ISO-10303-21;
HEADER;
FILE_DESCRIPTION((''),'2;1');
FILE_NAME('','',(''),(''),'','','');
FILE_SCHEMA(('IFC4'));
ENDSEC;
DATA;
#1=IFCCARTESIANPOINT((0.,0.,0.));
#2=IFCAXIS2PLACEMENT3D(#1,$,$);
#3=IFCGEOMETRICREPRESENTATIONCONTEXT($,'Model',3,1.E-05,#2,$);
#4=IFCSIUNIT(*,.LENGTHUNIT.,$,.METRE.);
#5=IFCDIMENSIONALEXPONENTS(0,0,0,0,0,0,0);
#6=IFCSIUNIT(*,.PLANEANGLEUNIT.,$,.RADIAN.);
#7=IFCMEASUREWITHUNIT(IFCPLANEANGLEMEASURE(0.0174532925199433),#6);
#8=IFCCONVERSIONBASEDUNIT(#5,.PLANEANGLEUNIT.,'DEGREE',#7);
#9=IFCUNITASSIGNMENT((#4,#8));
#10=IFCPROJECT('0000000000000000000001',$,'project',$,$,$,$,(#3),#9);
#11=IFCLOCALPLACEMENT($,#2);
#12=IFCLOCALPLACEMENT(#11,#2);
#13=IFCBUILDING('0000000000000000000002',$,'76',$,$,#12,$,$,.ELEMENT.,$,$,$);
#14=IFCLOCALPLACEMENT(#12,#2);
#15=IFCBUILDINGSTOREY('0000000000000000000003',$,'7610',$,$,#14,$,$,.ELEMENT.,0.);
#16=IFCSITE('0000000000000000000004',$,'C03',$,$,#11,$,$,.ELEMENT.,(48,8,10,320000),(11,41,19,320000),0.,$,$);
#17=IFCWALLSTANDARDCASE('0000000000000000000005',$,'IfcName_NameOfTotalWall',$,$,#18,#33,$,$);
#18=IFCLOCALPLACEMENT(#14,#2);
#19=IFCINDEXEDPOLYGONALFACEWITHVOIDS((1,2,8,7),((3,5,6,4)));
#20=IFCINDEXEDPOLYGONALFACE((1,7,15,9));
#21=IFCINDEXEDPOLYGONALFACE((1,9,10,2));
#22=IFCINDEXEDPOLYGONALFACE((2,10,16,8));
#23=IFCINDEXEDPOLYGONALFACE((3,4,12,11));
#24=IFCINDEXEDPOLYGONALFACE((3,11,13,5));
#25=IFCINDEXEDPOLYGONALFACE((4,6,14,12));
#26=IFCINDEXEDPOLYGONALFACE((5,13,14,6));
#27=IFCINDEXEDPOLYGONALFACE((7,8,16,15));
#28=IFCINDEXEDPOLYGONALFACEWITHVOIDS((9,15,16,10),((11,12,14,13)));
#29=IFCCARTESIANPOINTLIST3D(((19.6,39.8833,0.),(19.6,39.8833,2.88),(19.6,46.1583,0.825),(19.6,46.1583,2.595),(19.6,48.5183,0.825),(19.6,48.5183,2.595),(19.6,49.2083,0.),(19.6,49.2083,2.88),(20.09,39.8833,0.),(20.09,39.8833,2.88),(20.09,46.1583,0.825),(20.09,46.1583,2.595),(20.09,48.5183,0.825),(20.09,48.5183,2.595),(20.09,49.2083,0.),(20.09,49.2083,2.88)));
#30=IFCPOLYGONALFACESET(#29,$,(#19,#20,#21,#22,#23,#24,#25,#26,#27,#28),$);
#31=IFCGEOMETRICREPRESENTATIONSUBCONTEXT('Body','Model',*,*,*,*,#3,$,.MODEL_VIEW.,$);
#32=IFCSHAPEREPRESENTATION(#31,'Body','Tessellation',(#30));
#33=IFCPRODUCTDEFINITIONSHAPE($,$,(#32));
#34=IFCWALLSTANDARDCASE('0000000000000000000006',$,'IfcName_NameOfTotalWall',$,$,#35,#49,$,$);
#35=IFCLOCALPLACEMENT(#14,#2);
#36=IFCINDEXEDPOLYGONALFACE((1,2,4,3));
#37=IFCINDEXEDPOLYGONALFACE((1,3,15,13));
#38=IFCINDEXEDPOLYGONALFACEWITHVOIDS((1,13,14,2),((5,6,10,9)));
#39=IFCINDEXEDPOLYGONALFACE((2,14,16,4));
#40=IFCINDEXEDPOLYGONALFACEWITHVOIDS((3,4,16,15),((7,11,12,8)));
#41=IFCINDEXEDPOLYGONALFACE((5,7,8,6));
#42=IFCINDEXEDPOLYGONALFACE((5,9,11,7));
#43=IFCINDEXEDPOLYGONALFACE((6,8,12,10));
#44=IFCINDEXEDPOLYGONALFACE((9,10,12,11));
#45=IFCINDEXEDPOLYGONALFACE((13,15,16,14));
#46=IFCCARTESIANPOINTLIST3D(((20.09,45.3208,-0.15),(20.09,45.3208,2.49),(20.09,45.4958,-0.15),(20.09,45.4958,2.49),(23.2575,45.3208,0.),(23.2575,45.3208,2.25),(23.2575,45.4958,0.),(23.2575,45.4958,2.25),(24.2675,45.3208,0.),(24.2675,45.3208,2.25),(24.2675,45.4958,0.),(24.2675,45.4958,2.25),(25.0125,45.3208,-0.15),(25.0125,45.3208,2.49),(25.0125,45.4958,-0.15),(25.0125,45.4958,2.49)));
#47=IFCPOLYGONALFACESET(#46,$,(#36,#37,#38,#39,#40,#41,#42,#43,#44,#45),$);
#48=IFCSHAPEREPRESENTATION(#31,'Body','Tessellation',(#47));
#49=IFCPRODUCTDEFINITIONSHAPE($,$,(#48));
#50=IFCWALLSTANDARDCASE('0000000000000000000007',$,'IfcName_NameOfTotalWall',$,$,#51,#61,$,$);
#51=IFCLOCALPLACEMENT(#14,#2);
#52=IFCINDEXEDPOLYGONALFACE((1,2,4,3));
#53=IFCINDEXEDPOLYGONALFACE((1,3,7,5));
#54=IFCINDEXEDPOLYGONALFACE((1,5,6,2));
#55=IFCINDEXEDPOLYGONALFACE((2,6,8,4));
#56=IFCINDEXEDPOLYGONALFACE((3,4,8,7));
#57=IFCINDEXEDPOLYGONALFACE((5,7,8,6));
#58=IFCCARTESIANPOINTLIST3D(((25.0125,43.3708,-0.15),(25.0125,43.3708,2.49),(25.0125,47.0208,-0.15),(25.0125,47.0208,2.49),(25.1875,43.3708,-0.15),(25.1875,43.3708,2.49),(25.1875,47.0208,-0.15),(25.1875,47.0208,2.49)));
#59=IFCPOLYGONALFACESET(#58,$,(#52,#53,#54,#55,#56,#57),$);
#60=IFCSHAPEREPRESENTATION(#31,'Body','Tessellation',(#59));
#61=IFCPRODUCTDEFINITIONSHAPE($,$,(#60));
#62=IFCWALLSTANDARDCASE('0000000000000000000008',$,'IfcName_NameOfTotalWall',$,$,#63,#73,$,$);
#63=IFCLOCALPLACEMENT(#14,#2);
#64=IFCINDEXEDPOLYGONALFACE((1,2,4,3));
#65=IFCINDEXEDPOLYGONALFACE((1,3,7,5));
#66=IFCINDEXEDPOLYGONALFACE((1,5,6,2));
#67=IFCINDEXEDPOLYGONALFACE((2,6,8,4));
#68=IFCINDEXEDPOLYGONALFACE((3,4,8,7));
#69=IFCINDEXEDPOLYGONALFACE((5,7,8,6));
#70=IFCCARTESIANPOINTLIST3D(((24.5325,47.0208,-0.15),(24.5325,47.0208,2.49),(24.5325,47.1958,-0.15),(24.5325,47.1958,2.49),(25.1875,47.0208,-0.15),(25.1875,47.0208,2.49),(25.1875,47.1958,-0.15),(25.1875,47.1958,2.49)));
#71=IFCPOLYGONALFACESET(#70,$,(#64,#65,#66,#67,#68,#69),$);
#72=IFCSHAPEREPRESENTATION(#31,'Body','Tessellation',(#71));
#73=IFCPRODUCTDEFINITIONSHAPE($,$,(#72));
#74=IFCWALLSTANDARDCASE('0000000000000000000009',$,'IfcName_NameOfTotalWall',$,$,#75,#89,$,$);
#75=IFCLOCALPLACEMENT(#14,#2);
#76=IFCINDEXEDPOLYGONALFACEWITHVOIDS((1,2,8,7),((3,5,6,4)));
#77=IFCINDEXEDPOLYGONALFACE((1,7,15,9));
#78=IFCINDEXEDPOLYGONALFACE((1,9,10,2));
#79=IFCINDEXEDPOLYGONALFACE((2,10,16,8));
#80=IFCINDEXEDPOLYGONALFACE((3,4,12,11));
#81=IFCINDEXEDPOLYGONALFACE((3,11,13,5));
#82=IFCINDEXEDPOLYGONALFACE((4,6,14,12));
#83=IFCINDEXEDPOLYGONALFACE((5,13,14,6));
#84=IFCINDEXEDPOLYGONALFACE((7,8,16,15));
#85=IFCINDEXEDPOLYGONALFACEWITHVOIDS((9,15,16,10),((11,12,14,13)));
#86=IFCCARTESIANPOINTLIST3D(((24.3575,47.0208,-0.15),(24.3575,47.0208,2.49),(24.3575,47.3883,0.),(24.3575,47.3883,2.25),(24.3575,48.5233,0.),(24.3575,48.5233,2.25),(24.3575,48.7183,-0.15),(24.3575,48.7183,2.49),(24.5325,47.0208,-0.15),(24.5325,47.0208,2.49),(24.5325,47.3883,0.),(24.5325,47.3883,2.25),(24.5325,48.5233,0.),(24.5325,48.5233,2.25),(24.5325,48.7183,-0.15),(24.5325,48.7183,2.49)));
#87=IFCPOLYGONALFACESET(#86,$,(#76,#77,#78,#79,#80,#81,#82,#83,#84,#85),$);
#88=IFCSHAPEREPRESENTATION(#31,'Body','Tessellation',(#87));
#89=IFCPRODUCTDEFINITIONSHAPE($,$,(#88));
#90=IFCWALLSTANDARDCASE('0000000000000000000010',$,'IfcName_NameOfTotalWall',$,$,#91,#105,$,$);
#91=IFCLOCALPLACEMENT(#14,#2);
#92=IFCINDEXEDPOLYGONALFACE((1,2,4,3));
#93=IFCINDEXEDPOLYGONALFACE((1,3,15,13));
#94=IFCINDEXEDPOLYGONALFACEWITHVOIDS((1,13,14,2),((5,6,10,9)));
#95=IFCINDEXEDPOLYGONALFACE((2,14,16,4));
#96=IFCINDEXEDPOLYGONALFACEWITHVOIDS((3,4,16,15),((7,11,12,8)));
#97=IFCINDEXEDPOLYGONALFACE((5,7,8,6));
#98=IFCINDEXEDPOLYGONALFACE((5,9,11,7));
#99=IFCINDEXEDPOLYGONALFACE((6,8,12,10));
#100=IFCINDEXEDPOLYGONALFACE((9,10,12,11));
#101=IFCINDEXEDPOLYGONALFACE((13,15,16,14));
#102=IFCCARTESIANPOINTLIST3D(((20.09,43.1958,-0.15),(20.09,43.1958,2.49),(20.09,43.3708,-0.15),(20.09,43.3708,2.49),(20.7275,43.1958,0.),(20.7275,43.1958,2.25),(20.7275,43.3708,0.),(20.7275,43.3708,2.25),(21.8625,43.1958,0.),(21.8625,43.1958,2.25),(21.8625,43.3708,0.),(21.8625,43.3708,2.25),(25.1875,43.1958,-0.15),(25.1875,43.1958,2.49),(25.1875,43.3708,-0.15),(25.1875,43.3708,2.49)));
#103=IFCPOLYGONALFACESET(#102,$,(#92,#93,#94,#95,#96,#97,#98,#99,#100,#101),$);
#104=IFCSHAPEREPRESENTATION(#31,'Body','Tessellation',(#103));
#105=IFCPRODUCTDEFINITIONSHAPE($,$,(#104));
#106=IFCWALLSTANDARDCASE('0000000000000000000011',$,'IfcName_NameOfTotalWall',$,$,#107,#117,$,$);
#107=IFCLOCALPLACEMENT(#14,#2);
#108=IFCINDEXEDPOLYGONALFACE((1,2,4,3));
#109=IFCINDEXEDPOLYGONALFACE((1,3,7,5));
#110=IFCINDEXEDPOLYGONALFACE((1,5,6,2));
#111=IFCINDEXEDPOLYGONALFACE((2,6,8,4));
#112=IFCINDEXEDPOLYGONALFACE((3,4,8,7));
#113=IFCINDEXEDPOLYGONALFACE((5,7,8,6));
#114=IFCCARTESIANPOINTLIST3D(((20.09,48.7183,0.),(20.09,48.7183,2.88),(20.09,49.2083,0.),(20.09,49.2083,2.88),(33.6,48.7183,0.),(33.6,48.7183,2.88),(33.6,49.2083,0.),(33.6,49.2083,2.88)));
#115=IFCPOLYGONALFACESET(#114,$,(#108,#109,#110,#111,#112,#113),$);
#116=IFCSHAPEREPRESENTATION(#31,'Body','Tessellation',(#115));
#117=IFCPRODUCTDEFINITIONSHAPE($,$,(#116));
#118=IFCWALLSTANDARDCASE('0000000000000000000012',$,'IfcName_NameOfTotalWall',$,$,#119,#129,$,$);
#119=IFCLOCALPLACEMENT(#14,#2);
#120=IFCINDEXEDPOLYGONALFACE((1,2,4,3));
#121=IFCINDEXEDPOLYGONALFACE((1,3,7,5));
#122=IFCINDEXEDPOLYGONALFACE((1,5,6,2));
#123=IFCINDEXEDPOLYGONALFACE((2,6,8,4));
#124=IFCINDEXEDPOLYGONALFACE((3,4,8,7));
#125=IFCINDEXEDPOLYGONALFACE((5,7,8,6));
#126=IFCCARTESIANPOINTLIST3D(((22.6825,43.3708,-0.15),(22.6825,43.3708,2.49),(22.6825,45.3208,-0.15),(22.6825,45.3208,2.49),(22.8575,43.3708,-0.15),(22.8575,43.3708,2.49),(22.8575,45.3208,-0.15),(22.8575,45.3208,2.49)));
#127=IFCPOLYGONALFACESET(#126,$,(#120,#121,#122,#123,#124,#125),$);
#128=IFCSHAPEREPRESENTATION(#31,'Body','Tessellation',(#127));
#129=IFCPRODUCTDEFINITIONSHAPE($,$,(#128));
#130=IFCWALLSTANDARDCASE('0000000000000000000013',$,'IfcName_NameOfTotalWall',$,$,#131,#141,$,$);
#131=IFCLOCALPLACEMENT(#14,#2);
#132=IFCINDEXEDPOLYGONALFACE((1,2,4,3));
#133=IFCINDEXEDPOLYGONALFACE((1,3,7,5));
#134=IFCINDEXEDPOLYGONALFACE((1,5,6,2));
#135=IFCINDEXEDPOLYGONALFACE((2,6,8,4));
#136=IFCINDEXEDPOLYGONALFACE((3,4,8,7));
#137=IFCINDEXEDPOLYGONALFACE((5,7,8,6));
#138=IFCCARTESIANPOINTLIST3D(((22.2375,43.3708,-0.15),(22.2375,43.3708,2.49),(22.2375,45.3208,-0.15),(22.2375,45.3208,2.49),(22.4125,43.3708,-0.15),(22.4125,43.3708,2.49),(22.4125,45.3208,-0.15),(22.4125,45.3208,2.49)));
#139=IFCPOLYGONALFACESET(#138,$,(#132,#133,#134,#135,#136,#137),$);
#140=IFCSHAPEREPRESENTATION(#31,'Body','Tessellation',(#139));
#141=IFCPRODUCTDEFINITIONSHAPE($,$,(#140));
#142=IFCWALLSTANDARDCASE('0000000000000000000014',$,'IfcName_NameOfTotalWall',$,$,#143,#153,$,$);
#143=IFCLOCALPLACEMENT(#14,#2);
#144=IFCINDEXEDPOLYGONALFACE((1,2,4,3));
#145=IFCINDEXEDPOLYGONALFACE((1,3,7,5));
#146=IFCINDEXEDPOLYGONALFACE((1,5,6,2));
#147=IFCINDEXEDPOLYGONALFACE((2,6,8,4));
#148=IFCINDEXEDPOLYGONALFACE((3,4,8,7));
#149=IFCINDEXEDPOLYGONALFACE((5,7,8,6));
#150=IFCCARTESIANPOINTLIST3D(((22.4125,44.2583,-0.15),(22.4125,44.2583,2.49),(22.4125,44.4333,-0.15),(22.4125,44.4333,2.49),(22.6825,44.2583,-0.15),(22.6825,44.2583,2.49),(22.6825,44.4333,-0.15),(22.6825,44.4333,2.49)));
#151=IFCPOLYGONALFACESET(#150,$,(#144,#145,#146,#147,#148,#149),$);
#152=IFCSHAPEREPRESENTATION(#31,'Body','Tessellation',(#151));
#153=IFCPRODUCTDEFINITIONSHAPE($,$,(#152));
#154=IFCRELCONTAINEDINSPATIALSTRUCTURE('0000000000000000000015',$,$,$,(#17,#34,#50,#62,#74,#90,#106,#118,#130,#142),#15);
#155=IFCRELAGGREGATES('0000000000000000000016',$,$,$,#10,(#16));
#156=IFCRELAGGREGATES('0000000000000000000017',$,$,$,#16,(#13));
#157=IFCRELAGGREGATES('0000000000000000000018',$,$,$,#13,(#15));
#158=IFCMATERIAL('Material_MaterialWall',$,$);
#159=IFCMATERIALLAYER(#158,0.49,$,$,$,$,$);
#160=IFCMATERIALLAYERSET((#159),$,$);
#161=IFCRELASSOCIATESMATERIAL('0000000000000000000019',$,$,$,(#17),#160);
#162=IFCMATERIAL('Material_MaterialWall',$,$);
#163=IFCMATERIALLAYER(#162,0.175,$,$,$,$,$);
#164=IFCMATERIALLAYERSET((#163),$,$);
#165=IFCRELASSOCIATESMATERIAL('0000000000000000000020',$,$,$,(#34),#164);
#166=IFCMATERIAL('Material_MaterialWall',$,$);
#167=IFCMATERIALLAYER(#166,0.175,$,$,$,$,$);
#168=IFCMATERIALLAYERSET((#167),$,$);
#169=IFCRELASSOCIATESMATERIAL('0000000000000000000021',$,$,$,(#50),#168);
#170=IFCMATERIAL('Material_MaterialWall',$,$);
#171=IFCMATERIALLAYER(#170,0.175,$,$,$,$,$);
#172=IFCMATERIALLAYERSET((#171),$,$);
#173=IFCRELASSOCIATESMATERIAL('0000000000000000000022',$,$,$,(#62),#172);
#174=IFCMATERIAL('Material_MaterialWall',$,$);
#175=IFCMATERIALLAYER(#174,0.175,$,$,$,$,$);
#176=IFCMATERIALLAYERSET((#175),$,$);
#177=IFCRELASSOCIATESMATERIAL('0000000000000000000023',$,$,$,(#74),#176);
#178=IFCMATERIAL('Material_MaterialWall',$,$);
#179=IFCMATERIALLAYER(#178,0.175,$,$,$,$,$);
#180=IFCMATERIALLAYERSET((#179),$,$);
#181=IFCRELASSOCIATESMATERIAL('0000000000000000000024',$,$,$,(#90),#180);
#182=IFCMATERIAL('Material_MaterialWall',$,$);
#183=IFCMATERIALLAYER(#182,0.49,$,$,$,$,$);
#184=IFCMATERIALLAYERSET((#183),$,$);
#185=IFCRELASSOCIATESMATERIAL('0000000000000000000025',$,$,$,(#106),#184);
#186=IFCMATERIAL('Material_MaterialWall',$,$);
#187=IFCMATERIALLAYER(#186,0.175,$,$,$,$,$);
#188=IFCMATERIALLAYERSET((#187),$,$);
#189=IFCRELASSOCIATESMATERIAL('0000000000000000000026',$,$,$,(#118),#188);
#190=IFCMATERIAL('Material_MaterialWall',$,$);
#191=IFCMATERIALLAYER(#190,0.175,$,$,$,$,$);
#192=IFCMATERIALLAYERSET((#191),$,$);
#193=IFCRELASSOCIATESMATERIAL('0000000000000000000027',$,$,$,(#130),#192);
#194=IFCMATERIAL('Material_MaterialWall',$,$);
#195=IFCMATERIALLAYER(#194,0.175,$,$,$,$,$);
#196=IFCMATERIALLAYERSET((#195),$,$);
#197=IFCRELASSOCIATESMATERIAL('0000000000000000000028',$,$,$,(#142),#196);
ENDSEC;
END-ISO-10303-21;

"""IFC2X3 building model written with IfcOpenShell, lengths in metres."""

from ifc_helpers import new_model, entity, si_unit, converted_unit, frame, frame_2d, origin, origin_with_axes, place, context, subcontext, project, spatial, polyline, rectangle, outline, extrude, material, layer, layer_set, layer_usage, element, save


model = new_model("IFC2X3")

# Units and contexts
model_context = context("Model", 3, precision=1e-05, world=origin())
body_context = subcontext(model_context, "Body", "Model", "MODEL_VIEW")
ifc_project = project(units=[si_unit("LENGTHUNIT", "METRE"), converted_unit("PLANEANGLEUNIT", "DEGREE", entity("IfcPlaneAngleMeasure", 0.0174532925199433), si_unit("PLANEANGLEUNIT", "RADIAN"), dimensions=[0, 0, 0, 0, 0, 0, 0])], contexts=[model_context])

# Site, building, storey
site_placement = place(None, origin())
site = spatial("IfcSite", under=ifc_project, at=site_placement, Name="C03", CompositionType="ELEMENT", RefLatitude=(48, 8, 10, 320000), RefLongitude=(11, 41, 19, 320000), RefElevation=0.0)
building_placement = place(site_placement, origin())
building = spatial("IfcBuilding", under=site, at=building_placement, Name="76", CompositionType="ELEMENT")
storey_placement = place(building_placement, origin())
storey = spatial("IfcBuildingStorey", under=building, at=storey_placement, Name="7610", CompositionType="ELEMENT", Elevation=0.0)

# Walls, openings
ifc_material_1 = material(Name="Material_MaterialWall")
ifc_layer_1 = layer(ifc_material_1, 0.49)
ifc_layer_set_1 = layer_set([ifc_layer_1])
ifc_layer_usage_1 = layer_usage(ifc_layer_set_1, "AXIS2", "POSITIVE", -0.09)
wall_1_placement = place(storey_placement, frame((20.09, 39.8833, 0.0), z_axis=(0.0, 0.0, 1.0), x_axis=(0.0, 1.0, 0.0)))
wall_1 = element("IfcWallStandardCase", 1, at=wall_1_placement, inside=storey, material=ifc_layer_usage_1, Name="IfcName_NameOfTotalWall", context=body_context, shape_type="SweptSolid", body=[
    extrude(rectangle(XDim=9.325, YDim=0.49, at=frame_2d((4.6625, 0.245), x_axis=(1.0, 0.0))), origin_with_axes(), (0.0, 0.0, 1.0), 2.88),
])
opening_1_placement = place(wall_1_placement, frame((8.635, 0.49, 0.825), z_axis=(0.0, -1.0, 0.0), x_axis=(0.0, 0.0, 1.0)))
element("IfcOpeningElement", 2, at=opening_1_placement, cuts=wall_1, ObjectType="Opening", context=body_context, shape_type="SweptSolid", body=[
    extrude(outline(polyline([(0.0, 2.36), (1.77, 2.36), (1.77, 0.0), (0.0, 0.0), (0.0, 2.36)])), origin_with_axes(), (0.0, 0.0, 1.0), 0.49),
])
ifc_material_2 = material(Name="Material_MaterialWall")
ifc_layer_2 = layer(ifc_material_2, 0.175)
ifc_layer_set_2 = layer_set([ifc_layer_2])
ifc_layer_usage_2 = layer_usage(ifc_layer_set_2, "AXIS2", "POSITIVE", -0.0875)
wall_2_placement = place(storey_placement, frame((20.09, 45.3208, -0.15)))
wall_2 = element("IfcWallStandardCase", 3, at=wall_2_placement, inside=storey, material=ifc_layer_usage_2, Name="IfcName_NameOfTotalWall", context=body_context, shape_type="SweptSolid", body=[
    extrude(rectangle(XDim=4.9225, YDim=0.175, at=frame_2d((2.4613, 0.0875), x_axis=(1.0, 0.0))), origin_with_axes(), (0.0, 0.0, 1.0), 2.64),
])
opening_2_placement = place(wall_2_placement, frame((4.1775, 0.175, 0.15), z_axis=(0.0, -1.0, 0.0), x_axis=(0.0, 0.0, 1.0)))
element("IfcOpeningElement", 4, at=opening_2_placement, cuts=wall_2, ObjectType="Opening", context=body_context, shape_type="SweptSolid", body=[
    extrude(outline(polyline([(0.0, 1.01), (2.25, 1.01), (2.25, 0.0), (0.0, 0.0), (0.0, 1.01)])), origin_with_axes(), (0.0, 0.0, 1.0), 0.175),
])

# Walls
ifc_material_3 = material(Name="Material_MaterialWall")
ifc_layer_3 = layer(ifc_material_3, 0.175)
ifc_layer_set_3 = layer_set([ifc_layer_3])
ifc_layer_usage_3 = layer_usage(ifc_layer_set_3, "AXIS2", "POSITIVE", -0.0875)
wall_3_placement = place(storey_placement, frame((25.1875, 43.3708, -0.15), z_axis=(0.0, 0.0, 1.0), x_axis=(0.0, 1.0, 0.0)))
element("IfcWallStandardCase", 5, at=wall_3_placement, inside=storey, material=ifc_layer_usage_3, Name="IfcName_NameOfTotalWall", context=body_context, shape_type="SweptSolid", body=[
    extrude(rectangle(XDim=3.65, YDim=0.175, at=frame_2d((1.825, 0.0875), x_axis=(1.0, 0.0))), origin_with_axes(), (0.0, 0.0, 1.0), 2.64),
])
ifc_material_4 = material(Name="Material_MaterialWall")
ifc_layer_4 = layer(ifc_material_4, 0.175)
ifc_layer_set_4 = layer_set([ifc_layer_4])
ifc_layer_usage_4 = layer_usage(ifc_layer_set_4, "AXIS2", "POSITIVE", -0.0875)
wall_4_placement = place(storey_placement, frame((25.1875, 47.1958, -0.15), z_axis=(0.0, 0.0, 1.0), x_axis=(-1.0, 0.0, 0.0)))
element("IfcWallStandardCase", 6, at=wall_4_placement, inside=storey, material=ifc_layer_usage_4, Name="IfcName_NameOfTotalWall", context=body_context, shape_type="SweptSolid", body=[
    extrude(rectangle(XDim=0.655, YDim=0.175, at=frame_2d((0.3275, 0.0875), x_axis=(1.0, 0.0))), origin_with_axes(), (0.0, 0.0, 1.0), 2.64),
])

# Walls, openings
ifc_material_5 = material(Name="Material_MaterialWall")
ifc_layer_5 = layer(ifc_material_5, 0.175)
ifc_layer_set_5 = layer_set([ifc_layer_5])
ifc_layer_usage_5 = layer_usage(ifc_layer_set_5, "AXIS2", "POSITIVE", -0.0875)
wall_5_placement = place(storey_placement, frame((24.5325, 47.0208, -0.15), z_axis=(0.0, 0.0, 1.0), x_axis=(0.0, 1.0, 0.0)))
wall_5 = element("IfcWallStandardCase", 7, at=wall_5_placement, inside=storey, material=ifc_layer_usage_5, Name="IfcName_NameOfTotalWall", context=body_context, shape_type="SweptSolid", body=[
    extrude(rectangle(XDim=1.6975, YDim=0.175, at=frame_2d((0.8488, 0.0875), x_axis=(1.0, 0.0))), origin_with_axes(), (0.0, 0.0, 1.0), 2.64),
])
opening_3_placement = place(wall_5_placement, frame((0.3675, 0.0, 0.15), z_axis=(0.0, 1.0, 0.0), x_axis=(0.0, 0.0, 1.0)))
element("IfcOpeningElement", 8, at=opening_3_placement, cuts=wall_5, ObjectType="Opening", context=body_context, shape_type="SweptSolid", body=[
    extrude(outline(polyline([(0.0, 1.135), (2.25, 1.135), (2.25, 0.0), (0.0, 0.0), (0.0, 1.135)])), origin_with_axes(), (0.0, 0.0, 1.0), 0.175),
])
ifc_material_6 = material(Name="Material_MaterialWall")
ifc_layer_6 = layer(ifc_material_6, 0.175)
ifc_layer_set_6 = layer_set([ifc_layer_6])
ifc_layer_usage_6 = layer_usage(ifc_layer_set_6, "AXIS2", "POSITIVE", -0.0875)
wall_6_placement = place(storey_placement, frame((20.09, 43.1958, -0.15)))
wall_6 = element("IfcWallStandardCase", 9, at=wall_6_placement, inside=storey, material=ifc_layer_usage_6, Name="IfcName_NameOfTotalWall", context=body_context, shape_type="SweptSolid", body=[
    extrude(rectangle(XDim=5.0975, YDim=0.175, at=frame_2d((2.5488, 0.0875), x_axis=(1.0, 0.0))), origin_with_axes(), (0.0, 0.0, 1.0), 2.64),
])
opening_4_placement = place(wall_6_placement, frame((1.7725, 0.175, 0.15), z_axis=(0.0, -1.0, 0.0), x_axis=(0.0, 0.0, 1.0)))
element("IfcOpeningElement", 10, at=opening_4_placement, cuts=wall_6, ObjectType="Opening", context=body_context, shape_type="SweptSolid", body=[
    extrude(outline(polyline([(0.0, 1.135), (2.25, 1.135), (2.25, 0.0), (0.0, 0.0), (0.0, 1.135)])), origin_with_axes(), (0.0, 0.0, 1.0), 0.175),
])

# Walls
ifc_material_7 = material(Name="Material_MaterialWall")
ifc_layer_7 = layer(ifc_material_7, 0.49)
ifc_layer_set_7 = layer_set([ifc_layer_7])
ifc_layer_usage_7 = layer_usage(ifc_layer_set_7, "AXIS2", "POSITIVE", -0.09)
wall_7_placement = place(storey_placement, frame((20.09, 48.7183, 0.0)))
element("IfcWallStandardCase", 11, at=wall_7_placement, inside=storey, material=ifc_layer_usage_7, Name="IfcName_NameOfTotalWall", context=body_context, shape_type="SweptSolid", body=[
    extrude(rectangle(XDim=13.51, YDim=0.49, at=frame_2d((6.755, 0.245), x_axis=(1.0, 0.0))), origin_with_axes(), (0.0, 0.0, 1.0), 2.88),
])
ifc_material_8 = material(Name="Material_MaterialWall")
ifc_layer_8 = layer(ifc_material_8, 0.175)
ifc_layer_set_8 = layer_set([ifc_layer_8])
ifc_layer_usage_8 = layer_usage(ifc_layer_set_8, "AXIS2", "POSITIVE", -0.0875)
wall_8_placement = place(storey_placement, frame((22.6825, 45.3208, -0.15), z_axis=(0.0, 0.0, 1.0), x_axis=(0.0, -1.0, 0.0)))
element("IfcWallStandardCase", 12, at=wall_8_placement, inside=storey, material=ifc_layer_usage_8, Name="IfcName_NameOfTotalWall", context=body_context, shape_type="SweptSolid", body=[
    extrude(rectangle(XDim=1.95, YDim=0.175, at=frame_2d((0.975, 0.0875), x_axis=(1.0, 0.0))), origin_with_axes(), (0.0, 0.0, 1.0), 2.64),
])
ifc_material_9 = material(Name="Material_MaterialWall")
ifc_layer_9 = layer(ifc_material_9, 0.175)
ifc_layer_set_9 = layer_set([ifc_layer_9])
ifc_layer_usage_9 = layer_usage(ifc_layer_set_9, "AXIS2", "POSITIVE", -0.0875)
wall_9_placement = place(storey_placement, frame((22.2375, 45.3208, -0.15), z_axis=(0.0, 0.0, 1.0), x_axis=(0.0, -1.0, 0.0)))
element("IfcWallStandardCase", 13, at=wall_9_placement, inside=storey, material=ifc_layer_usage_9, Name="IfcName_NameOfTotalWall", context=body_context, shape_type="SweptSolid", body=[
    extrude(rectangle(XDim=1.95, YDim=0.175, at=frame_2d((0.975, 0.0875), x_axis=(1.0, 0.0))), origin_with_axes(), (0.0, 0.0, 1.0), 2.64),
])
ifc_material_10 = material(Name="Material_MaterialWall")
ifc_layer_10 = layer(ifc_material_10, 0.175)
ifc_layer_set_10 = layer_set([ifc_layer_10])
ifc_layer_usage_10 = layer_usage(ifc_layer_set_10, "AXIS2", "POSITIVE", -0.0875)
wall_10_placement = place(storey_placement, frame((22.4125, 44.2583, -0.15)))
element("IfcWallStandardCase", 14, at=wall_10_placement, inside=storey, material=ifc_layer_usage_10, Name="IfcName_NameOfTotalWall", context=body_context, shape_type="SweptSolid", body=[
    extrude(rectangle(XDim=0.27, YDim=0.175, at=frame_2d((0.135, 0.0875), x_axis=(1.0, 0.0))), origin_with_axes(), (0.0, 0.0, 1.0), 2.64),
])

save(model, "model.ifc")
